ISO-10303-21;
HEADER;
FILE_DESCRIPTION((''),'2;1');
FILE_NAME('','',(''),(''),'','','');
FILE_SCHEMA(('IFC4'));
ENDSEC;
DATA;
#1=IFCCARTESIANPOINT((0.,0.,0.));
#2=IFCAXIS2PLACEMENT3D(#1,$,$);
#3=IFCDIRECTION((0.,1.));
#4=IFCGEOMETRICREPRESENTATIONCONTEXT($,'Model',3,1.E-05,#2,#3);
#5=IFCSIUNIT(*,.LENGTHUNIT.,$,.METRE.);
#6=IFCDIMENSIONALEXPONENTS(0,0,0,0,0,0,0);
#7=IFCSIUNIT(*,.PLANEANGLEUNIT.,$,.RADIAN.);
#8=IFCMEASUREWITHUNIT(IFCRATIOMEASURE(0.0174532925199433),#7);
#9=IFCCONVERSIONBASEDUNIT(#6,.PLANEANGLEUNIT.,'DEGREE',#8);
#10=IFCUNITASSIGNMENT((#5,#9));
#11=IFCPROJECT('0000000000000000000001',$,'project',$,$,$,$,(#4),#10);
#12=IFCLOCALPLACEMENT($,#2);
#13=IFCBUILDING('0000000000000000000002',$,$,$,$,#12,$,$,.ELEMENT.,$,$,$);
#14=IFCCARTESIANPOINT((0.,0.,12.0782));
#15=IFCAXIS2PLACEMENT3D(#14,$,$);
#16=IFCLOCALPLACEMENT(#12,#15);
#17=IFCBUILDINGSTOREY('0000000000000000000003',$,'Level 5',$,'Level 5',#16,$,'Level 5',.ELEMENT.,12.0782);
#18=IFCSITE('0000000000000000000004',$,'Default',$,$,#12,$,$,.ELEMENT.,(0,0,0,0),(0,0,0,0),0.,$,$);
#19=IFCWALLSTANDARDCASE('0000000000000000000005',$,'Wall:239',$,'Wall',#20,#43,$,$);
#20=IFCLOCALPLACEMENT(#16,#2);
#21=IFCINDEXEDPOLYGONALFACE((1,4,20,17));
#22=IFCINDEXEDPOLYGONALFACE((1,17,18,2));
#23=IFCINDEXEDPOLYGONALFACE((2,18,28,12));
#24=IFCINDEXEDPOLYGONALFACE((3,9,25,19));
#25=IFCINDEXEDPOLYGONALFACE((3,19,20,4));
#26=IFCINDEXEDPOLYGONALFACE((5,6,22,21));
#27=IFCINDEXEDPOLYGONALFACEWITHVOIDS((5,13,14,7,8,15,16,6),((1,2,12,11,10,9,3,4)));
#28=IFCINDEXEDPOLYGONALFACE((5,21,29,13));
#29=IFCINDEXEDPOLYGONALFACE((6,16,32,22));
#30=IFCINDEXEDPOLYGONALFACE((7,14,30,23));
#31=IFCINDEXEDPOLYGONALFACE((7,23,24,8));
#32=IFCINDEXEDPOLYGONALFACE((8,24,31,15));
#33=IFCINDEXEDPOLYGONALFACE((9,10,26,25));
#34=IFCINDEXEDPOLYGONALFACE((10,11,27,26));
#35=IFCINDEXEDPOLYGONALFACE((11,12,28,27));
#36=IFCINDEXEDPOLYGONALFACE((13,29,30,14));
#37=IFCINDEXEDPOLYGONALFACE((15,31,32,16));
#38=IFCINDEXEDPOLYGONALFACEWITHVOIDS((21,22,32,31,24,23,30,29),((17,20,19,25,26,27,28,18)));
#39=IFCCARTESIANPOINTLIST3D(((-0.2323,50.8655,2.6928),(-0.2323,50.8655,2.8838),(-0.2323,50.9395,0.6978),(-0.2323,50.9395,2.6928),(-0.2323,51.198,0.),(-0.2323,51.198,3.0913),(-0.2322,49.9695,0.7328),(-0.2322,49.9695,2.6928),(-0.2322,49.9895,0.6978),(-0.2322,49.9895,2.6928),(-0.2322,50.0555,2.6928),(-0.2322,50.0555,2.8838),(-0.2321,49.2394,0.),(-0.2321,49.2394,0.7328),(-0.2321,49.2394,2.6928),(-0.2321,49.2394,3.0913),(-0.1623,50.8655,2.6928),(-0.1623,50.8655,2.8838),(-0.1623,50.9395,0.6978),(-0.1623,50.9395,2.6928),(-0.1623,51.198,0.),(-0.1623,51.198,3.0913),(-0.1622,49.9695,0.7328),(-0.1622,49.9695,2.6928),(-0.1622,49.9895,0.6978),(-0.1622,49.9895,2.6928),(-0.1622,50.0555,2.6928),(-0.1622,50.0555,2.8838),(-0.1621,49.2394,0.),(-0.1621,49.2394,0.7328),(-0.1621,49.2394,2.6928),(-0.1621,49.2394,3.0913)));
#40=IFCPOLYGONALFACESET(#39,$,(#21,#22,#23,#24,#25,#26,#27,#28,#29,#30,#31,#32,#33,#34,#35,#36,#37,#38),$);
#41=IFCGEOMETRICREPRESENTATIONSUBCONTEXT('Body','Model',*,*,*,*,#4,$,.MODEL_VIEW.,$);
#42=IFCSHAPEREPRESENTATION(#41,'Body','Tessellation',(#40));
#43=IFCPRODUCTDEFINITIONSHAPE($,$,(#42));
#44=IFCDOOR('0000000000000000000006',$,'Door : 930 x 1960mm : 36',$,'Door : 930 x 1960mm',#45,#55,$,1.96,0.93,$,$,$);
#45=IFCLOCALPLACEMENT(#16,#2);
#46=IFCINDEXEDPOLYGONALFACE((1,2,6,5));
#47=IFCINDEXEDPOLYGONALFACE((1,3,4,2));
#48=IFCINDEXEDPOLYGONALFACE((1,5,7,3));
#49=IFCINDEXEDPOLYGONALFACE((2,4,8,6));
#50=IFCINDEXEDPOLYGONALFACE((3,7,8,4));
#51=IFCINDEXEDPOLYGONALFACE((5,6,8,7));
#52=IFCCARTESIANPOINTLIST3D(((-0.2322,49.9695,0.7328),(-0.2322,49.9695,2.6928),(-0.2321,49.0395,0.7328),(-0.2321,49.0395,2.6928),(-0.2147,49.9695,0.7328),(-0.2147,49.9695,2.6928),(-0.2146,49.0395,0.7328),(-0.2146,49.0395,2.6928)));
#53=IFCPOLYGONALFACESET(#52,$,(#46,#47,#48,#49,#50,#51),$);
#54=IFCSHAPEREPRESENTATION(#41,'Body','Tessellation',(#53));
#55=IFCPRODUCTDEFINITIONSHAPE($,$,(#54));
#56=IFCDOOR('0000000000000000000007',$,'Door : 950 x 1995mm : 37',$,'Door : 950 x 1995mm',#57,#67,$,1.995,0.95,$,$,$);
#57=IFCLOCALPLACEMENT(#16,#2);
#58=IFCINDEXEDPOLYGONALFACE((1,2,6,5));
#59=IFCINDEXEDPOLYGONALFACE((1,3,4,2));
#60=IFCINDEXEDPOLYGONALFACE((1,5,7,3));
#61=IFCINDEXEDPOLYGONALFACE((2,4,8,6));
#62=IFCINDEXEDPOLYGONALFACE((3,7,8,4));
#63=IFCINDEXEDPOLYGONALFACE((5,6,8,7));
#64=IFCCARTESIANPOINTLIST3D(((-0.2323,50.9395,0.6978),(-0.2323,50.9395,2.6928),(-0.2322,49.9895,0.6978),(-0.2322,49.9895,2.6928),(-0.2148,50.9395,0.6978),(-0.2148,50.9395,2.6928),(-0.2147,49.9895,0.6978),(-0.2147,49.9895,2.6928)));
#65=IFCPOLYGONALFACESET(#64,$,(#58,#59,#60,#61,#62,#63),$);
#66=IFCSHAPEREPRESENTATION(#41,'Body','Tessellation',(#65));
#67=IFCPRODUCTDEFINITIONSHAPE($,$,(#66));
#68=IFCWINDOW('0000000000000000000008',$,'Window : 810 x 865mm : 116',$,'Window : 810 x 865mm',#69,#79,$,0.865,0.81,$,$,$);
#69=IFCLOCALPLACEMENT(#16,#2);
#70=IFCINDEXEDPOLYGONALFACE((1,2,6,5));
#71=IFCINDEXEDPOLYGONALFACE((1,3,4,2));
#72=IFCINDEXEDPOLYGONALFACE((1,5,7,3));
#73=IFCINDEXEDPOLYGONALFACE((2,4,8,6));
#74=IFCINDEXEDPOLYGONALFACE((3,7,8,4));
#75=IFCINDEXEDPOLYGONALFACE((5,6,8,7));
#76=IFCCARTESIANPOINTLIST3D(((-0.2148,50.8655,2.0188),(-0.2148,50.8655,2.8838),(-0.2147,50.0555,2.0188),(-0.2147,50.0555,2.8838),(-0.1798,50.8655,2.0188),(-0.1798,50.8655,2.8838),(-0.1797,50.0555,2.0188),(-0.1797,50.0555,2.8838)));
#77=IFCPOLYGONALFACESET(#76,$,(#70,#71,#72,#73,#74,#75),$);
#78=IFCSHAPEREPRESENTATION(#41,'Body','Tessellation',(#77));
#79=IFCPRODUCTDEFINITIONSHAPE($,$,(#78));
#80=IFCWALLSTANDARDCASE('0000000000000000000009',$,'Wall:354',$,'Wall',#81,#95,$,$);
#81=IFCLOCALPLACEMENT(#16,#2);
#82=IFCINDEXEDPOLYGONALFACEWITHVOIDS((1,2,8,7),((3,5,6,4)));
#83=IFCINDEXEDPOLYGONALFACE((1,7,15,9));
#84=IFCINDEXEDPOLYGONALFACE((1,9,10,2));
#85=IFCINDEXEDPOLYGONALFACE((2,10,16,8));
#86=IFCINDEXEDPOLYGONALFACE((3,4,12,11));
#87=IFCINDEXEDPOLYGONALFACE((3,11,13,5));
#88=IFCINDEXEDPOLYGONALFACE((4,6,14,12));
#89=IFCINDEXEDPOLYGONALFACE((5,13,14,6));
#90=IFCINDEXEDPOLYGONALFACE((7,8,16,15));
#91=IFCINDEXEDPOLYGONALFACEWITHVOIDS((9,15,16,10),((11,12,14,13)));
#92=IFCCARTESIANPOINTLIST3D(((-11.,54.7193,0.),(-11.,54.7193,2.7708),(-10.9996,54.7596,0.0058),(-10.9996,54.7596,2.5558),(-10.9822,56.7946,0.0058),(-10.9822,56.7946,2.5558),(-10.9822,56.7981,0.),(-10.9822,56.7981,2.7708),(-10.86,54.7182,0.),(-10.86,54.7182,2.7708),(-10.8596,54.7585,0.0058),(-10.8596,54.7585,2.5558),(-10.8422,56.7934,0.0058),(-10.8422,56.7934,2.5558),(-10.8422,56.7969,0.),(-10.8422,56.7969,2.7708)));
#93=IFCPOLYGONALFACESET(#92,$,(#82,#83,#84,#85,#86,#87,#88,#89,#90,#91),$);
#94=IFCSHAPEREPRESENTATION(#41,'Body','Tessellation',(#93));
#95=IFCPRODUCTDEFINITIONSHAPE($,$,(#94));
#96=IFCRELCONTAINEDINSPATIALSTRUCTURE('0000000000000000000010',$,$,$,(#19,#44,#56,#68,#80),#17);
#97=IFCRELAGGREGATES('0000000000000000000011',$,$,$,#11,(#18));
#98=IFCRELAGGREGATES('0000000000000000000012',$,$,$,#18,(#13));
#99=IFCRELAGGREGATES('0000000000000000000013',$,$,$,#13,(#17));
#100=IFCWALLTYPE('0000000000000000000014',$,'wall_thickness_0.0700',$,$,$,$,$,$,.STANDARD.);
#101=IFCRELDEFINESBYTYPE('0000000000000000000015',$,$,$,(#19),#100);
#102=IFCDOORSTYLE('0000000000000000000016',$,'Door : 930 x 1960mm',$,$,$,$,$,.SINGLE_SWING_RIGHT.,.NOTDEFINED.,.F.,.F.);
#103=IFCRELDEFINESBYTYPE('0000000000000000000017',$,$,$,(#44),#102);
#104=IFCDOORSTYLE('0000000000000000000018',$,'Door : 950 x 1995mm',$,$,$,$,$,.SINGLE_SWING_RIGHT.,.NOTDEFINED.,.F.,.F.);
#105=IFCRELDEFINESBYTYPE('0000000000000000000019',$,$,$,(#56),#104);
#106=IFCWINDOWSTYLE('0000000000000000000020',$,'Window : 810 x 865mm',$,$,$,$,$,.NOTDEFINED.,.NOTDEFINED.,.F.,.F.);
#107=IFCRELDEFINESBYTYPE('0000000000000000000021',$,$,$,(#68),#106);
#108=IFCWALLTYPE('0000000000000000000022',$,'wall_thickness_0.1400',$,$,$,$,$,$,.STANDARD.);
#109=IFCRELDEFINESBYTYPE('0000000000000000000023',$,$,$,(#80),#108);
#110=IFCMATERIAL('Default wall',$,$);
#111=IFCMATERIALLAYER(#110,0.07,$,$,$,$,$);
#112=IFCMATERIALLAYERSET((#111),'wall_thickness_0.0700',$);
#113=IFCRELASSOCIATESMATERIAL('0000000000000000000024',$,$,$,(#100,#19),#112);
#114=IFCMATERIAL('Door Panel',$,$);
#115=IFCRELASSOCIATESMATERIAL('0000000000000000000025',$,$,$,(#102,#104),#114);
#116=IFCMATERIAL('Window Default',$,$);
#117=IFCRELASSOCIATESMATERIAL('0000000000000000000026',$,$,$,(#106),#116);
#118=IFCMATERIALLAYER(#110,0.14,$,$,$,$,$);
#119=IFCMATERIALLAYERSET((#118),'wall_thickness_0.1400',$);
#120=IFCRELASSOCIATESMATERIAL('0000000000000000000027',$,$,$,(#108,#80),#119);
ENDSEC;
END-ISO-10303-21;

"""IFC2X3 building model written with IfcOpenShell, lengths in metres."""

from ifc_helpers import new_model, entity, si_unit, converted_unit, direction, frame, frame_2d, origin, origin_2d_with_axis, place, context, subcontext, project, spatial, polyline, rectangle, outline, extrude, clip, halfspace, source, transform, mapped, material, layer, layer_set, layer_usage, type_object, type_shapes, element, fill, save


model = new_model("IFC2X3")

# Units and contexts
model_context = context("Model", 3, precision=1e-05, world=origin(), true_north=direction((0.0, 1.0)))
body_context = subcontext(model_context, "Body", "Model", "MODEL_VIEW")
ifc_project = project(units=[si_unit("LENGTHUNIT", "METRE"), converted_unit("PLANEANGLEUNIT", "DEGREE", entity("IfcRatioMeasure", 0.0174532925199433), si_unit("PLANEANGLEUNIT", "RADIAN"), dimensions=[0, 0, 0, 0, 0, 0, 0])], contexts=[model_context])

# Site, building, storey
placement = place(None, origin())
site = spatial("IfcSite", under=ifc_project, at=placement, Name="Default", CompositionType="ELEMENT", RefLatitude=(0, 0, 0, 0), RefLongitude=(0, 0, 0, 0), RefElevation=0.0)
building = spatial("IfcBuilding", under=site, at=placement, CompositionType="ELEMENT")
storey_placement = place(placement, frame((0.0, 0.0, 12.0782)))
storey = spatial("IfcBuildingStorey", under=building, at=storey_placement, Name="Level 5", ObjectType="Level 5", LongName="Level 5", CompositionType="ELEMENT", Elevation=12.0782)

# Shared definitions
ifc_material_1 = material(Name="Default wall")

# Shared definitions
ifc_material_2 = material(Name="Door Panel")

# Shared definitions
ifc_material_3 = material(Name="Window Default")

# Wall, openings, doors, window
ifc_layer_1 = layer(ifc_material_1, 0.07)
ifc_layer_set_1 = layer_set([ifc_layer_1], Name="wall_thickness_0.0700")
ifc_layer_usage_1 = layer_usage(ifc_layer_set_1, "AXIS2", "POSITIVE", -0.035)
wall_type_1 = type_object("IfcWallType", Name="wall_thickness_0.0700", PredefinedType="STANDARD", material=ifc_layer_set_1)
wall_1_placement = place(storey_placement, frame((-0.1971, 49.2394, 0.0), z_axis=(0.0, 0.0, 1.0), x_axis=(-0.000117, 1.0, 0.0)))
wall_1 = element("IfcWallStandardCase", 1, at=wall_1_placement, inside=storey, type_object=wall_type_1, material=ifc_layer_usage_1, Name="Wall:239", ObjectType="Wall", context=body_context, shape_type="Clipping", body=[
    clip(clip(extrude(outline(polyline([(1.9585, -0.035), (1.9585, 0.035), (0.0, 0.035), (0.0, -0.035), (1.9585, -0.035)])), origin(), (0.0, 0.0, 1.0), 3.0913), halfspace(frame((8.5693, 12.555, 9.0175), z_axis=(-0.39111, 0.003934, 0.920336), x_axis=(-0.008267, -0.999966, 0.000761)), False)), halfspace(frame((26.6045, 1.0626, 5.7957), z_axis=(0.00146, 0.389898, 0.920857), x_axis=(-0.005655, -0.920839, 0.389903)), False)),
])
opening_1_placement = place(wall_1_placement, frame((-0.1999, -0.035, 0.7328)))
opening_1 = element("IfcOpeningElement", 2, at=opening_1_placement, cuts=wall_1, ObjectType="Opening", context=body_context, shape_type="SweptSolid", body=[
    extrude(rectangle(XDim=0.93, YDim=1.96, at=frame_2d((0.98, 0.465), x_axis=(0.0, 1.0))), frame((0.0, 0.0, 0.0), z_axis=(0.0, 1.0, 0.0), x_axis=(0.0, 0.0, 1.0)), (0.0, 0.0, 1.0), 0.07),
])
opening_2_placement = place(wall_1_placement, frame((0.7501, -0.035, 0.6978)))
opening_2 = element("IfcOpeningElement", 3, at=opening_2_placement, cuts=wall_1, ObjectType="Opening", context=body_context, shape_type="SweptSolid", body=[
    extrude(rectangle(XDim=0.95, YDim=1.995, at=frame_2d((0.9975, 0.475), x_axis=(0.0, 1.0))), frame((0.0, 0.0, 0.0), z_axis=(0.0, 1.0, 0.0), x_axis=(0.0, 0.0, 1.0)), (0.0, 0.0, 1.0), 0.07),
])
opening_3_placement = place(wall_1_placement, frame((0.8161, -0.035, 2.0188)))
opening_3 = element("IfcOpeningElement", 4, at=opening_3_placement, cuts=wall_1, ObjectType="Opening", context=body_context, shape_type="SweptSolid", body=[
    extrude(rectangle(XDim=0.81, YDim=0.865, at=frame_2d((0.4325, 0.405), x_axis=(0.0, 1.0))), frame((0.0, 0.0, 0.0), z_axis=(0.0, 1.0, 0.0), x_axis=(0.0, 0.0, 1.0)), (0.0, 0.0, 1.0), 0.07),
])
door_style_1 = type_object("IfcDoorStyle", Name="Door : 930 x 1960mm", ConstructionType="NOTDEFINED", OperationType="SINGLE_SWING_RIGHT", ParameterTakesPrecedence=False, Sizeable=False, material=ifc_material_2)
shared_shape_1 = source(origin(), body_context, "Body", "SweptSolid", [
    extrude(rectangle(XDim=0.0175, YDim=0.93, at=origin_2d_with_axis()), frame((0.465, 0.0613, 0.0), z_axis=(0.0, 0.0, 1.0), x_axis=(0.0, 1.0, 0.0)), (0.0, 0.0, 1.0), 1.96),
])
type_shapes(door_style_1, [shared_shape_1])
door_1_placement = place(opening_1_placement, origin())
door_1 = element("IfcDoor", 5, at=door_1_placement, inside=storey, type_object=door_style_1, Name="Door : 930 x 1960mm : 36", ObjectType="Door : 930 x 1960mm", OverallHeight=1.96, OverallWidth=0.93, context=body_context, shape_type="MappedRepresentation", body=[
    mapped(shared_shape_1, transform((0.0, 0.0, 0.0), scale=1.0)),
])
fill(opening_1, door_1)
door_style_2 = type_object("IfcDoorStyle", Name="Door : 950 x 1995mm", ConstructionType="NOTDEFINED", OperationType="SINGLE_SWING_RIGHT", ParameterTakesPrecedence=False, Sizeable=False, material=ifc_material_2)
shared_shape_2 = source(origin(), body_context, "Body", "SweptSolid", [
    extrude(rectangle(XDim=0.0175, YDim=0.95, at=origin_2d_with_axis()), frame((0.475, 0.0613, 0.0), z_axis=(0.0, 0.0, 1.0), x_axis=(0.0, 1.0, 0.0)), (0.0, 0.0, 1.0), 1.995),
])
type_shapes(door_style_2, [shared_shape_2])
door_2_placement = place(opening_2_placement, origin())
door_2 = element("IfcDoor", 6, at=door_2_placement, inside=storey, type_object=door_style_2, Name="Door : 950 x 1995mm : 37", ObjectType="Door : 950 x 1995mm", OverallHeight=1.995, OverallWidth=0.95, context=body_context, shape_type="MappedRepresentation", body=[
    mapped(shared_shape_2, transform((0.0, 0.0, 0.0), scale=1.0)),
])
fill(opening_2, door_2)
window_style_1 = type_object("IfcWindowStyle", Name="Window : 810 x 865mm", ConstructionType="NOTDEFINED", OperationType="NOTDEFINED", ParameterTakesPrecedence=False, Sizeable=False, material=ifc_material_3)
shared_shape_3 = source(origin(), body_context, "Body", "SweptSolid", [
    extrude(rectangle(XDim=0.035, YDim=0.81, at=origin_2d_with_axis()), frame((0.405, 0.035, 0.0), z_axis=(0.0, 0.0, 1.0), x_axis=(0.0, 1.0, 0.0)), (0.0, 0.0, 1.0), 0.865),
])
type_shapes(window_style_1, [shared_shape_3])
window_1_placement = place(opening_3_placement, origin())
window_1 = element("IfcWindow", 7, at=window_1_placement, inside=storey, type_object=window_style_1, Name="Window : 810 x 865mm : 116", ObjectType="Window : 810 x 865mm", OverallHeight=0.865, OverallWidth=0.81, context=body_context, shape_type="MappedRepresentation", body=[
    mapped(shared_shape_3, transform((0.0, 0.0, 0.0), scale=1.0)),
])
fill(opening_3, window_1)

# Wall, opening
ifc_layer_2 = layer(ifc_material_1, 0.14)
ifc_layer_set_2 = layer_set([ifc_layer_2], Name="wall_thickness_0.1400")
ifc_layer_usage_2 = layer_usage(ifc_layer_set_2, "AXIS2", "POSITIVE", -0.07)
wall_type_2 = type_object("IfcWallType", Name="wall_thickness_0.1400", PredefinedType="STANDARD", material=ifc_layer_set_2)
wall_2_placement = place(storey_placement, frame((-10.9122, 56.7975, 0.0), z_axis=(0.0, 0.0, 1.0), x_axis=(-0.00855, -0.999963, 0.0)))
wall_2 = element("IfcWallStandardCase", 8, at=wall_2_placement, inside=storey, type_object=wall_type_2, material=ifc_layer_usage_2, Name="Wall:354", ObjectType="Wall", context=body_context, shape_type="Clipping", body=[
    clip(extrude(outline(polyline([(2.0789, -0.07), (2.0789, 0.07), (0.0, 0.07), (0.0, -0.07), (2.0789, -0.07)])), origin(), (0.0, 0.0, 1.0), 2.7708), halfspace(frame((-0.9939, -1.8495, 9.0175), z_axis=(0.391129, -0.000544, 0.920336), x_axis=(-0.0004, 1.0, 0.000761)), False)),
])
opening_4_placement = place(wall_2_placement, frame((0.0036, -0.07, 0.0058)))
element("IfcOpeningElement", 9, at=opening_4_placement, cuts=wall_2, ObjectType="Opening", context=body_context, shape_type="SweptSolid", body=[
    extrude(rectangle(XDim=2.035, YDim=2.55, at=frame_2d((1.275, 1.0175), x_axis=(0.0, 1.0))), frame((0.0, 0.0, 0.0), z_axis=(0.0, 1.0, 0.0), x_axis=(0.0, 0.0, 1.0)), (0.0, 0.0, 1.0), 0.14),
])

save(model, "model.ifc")
